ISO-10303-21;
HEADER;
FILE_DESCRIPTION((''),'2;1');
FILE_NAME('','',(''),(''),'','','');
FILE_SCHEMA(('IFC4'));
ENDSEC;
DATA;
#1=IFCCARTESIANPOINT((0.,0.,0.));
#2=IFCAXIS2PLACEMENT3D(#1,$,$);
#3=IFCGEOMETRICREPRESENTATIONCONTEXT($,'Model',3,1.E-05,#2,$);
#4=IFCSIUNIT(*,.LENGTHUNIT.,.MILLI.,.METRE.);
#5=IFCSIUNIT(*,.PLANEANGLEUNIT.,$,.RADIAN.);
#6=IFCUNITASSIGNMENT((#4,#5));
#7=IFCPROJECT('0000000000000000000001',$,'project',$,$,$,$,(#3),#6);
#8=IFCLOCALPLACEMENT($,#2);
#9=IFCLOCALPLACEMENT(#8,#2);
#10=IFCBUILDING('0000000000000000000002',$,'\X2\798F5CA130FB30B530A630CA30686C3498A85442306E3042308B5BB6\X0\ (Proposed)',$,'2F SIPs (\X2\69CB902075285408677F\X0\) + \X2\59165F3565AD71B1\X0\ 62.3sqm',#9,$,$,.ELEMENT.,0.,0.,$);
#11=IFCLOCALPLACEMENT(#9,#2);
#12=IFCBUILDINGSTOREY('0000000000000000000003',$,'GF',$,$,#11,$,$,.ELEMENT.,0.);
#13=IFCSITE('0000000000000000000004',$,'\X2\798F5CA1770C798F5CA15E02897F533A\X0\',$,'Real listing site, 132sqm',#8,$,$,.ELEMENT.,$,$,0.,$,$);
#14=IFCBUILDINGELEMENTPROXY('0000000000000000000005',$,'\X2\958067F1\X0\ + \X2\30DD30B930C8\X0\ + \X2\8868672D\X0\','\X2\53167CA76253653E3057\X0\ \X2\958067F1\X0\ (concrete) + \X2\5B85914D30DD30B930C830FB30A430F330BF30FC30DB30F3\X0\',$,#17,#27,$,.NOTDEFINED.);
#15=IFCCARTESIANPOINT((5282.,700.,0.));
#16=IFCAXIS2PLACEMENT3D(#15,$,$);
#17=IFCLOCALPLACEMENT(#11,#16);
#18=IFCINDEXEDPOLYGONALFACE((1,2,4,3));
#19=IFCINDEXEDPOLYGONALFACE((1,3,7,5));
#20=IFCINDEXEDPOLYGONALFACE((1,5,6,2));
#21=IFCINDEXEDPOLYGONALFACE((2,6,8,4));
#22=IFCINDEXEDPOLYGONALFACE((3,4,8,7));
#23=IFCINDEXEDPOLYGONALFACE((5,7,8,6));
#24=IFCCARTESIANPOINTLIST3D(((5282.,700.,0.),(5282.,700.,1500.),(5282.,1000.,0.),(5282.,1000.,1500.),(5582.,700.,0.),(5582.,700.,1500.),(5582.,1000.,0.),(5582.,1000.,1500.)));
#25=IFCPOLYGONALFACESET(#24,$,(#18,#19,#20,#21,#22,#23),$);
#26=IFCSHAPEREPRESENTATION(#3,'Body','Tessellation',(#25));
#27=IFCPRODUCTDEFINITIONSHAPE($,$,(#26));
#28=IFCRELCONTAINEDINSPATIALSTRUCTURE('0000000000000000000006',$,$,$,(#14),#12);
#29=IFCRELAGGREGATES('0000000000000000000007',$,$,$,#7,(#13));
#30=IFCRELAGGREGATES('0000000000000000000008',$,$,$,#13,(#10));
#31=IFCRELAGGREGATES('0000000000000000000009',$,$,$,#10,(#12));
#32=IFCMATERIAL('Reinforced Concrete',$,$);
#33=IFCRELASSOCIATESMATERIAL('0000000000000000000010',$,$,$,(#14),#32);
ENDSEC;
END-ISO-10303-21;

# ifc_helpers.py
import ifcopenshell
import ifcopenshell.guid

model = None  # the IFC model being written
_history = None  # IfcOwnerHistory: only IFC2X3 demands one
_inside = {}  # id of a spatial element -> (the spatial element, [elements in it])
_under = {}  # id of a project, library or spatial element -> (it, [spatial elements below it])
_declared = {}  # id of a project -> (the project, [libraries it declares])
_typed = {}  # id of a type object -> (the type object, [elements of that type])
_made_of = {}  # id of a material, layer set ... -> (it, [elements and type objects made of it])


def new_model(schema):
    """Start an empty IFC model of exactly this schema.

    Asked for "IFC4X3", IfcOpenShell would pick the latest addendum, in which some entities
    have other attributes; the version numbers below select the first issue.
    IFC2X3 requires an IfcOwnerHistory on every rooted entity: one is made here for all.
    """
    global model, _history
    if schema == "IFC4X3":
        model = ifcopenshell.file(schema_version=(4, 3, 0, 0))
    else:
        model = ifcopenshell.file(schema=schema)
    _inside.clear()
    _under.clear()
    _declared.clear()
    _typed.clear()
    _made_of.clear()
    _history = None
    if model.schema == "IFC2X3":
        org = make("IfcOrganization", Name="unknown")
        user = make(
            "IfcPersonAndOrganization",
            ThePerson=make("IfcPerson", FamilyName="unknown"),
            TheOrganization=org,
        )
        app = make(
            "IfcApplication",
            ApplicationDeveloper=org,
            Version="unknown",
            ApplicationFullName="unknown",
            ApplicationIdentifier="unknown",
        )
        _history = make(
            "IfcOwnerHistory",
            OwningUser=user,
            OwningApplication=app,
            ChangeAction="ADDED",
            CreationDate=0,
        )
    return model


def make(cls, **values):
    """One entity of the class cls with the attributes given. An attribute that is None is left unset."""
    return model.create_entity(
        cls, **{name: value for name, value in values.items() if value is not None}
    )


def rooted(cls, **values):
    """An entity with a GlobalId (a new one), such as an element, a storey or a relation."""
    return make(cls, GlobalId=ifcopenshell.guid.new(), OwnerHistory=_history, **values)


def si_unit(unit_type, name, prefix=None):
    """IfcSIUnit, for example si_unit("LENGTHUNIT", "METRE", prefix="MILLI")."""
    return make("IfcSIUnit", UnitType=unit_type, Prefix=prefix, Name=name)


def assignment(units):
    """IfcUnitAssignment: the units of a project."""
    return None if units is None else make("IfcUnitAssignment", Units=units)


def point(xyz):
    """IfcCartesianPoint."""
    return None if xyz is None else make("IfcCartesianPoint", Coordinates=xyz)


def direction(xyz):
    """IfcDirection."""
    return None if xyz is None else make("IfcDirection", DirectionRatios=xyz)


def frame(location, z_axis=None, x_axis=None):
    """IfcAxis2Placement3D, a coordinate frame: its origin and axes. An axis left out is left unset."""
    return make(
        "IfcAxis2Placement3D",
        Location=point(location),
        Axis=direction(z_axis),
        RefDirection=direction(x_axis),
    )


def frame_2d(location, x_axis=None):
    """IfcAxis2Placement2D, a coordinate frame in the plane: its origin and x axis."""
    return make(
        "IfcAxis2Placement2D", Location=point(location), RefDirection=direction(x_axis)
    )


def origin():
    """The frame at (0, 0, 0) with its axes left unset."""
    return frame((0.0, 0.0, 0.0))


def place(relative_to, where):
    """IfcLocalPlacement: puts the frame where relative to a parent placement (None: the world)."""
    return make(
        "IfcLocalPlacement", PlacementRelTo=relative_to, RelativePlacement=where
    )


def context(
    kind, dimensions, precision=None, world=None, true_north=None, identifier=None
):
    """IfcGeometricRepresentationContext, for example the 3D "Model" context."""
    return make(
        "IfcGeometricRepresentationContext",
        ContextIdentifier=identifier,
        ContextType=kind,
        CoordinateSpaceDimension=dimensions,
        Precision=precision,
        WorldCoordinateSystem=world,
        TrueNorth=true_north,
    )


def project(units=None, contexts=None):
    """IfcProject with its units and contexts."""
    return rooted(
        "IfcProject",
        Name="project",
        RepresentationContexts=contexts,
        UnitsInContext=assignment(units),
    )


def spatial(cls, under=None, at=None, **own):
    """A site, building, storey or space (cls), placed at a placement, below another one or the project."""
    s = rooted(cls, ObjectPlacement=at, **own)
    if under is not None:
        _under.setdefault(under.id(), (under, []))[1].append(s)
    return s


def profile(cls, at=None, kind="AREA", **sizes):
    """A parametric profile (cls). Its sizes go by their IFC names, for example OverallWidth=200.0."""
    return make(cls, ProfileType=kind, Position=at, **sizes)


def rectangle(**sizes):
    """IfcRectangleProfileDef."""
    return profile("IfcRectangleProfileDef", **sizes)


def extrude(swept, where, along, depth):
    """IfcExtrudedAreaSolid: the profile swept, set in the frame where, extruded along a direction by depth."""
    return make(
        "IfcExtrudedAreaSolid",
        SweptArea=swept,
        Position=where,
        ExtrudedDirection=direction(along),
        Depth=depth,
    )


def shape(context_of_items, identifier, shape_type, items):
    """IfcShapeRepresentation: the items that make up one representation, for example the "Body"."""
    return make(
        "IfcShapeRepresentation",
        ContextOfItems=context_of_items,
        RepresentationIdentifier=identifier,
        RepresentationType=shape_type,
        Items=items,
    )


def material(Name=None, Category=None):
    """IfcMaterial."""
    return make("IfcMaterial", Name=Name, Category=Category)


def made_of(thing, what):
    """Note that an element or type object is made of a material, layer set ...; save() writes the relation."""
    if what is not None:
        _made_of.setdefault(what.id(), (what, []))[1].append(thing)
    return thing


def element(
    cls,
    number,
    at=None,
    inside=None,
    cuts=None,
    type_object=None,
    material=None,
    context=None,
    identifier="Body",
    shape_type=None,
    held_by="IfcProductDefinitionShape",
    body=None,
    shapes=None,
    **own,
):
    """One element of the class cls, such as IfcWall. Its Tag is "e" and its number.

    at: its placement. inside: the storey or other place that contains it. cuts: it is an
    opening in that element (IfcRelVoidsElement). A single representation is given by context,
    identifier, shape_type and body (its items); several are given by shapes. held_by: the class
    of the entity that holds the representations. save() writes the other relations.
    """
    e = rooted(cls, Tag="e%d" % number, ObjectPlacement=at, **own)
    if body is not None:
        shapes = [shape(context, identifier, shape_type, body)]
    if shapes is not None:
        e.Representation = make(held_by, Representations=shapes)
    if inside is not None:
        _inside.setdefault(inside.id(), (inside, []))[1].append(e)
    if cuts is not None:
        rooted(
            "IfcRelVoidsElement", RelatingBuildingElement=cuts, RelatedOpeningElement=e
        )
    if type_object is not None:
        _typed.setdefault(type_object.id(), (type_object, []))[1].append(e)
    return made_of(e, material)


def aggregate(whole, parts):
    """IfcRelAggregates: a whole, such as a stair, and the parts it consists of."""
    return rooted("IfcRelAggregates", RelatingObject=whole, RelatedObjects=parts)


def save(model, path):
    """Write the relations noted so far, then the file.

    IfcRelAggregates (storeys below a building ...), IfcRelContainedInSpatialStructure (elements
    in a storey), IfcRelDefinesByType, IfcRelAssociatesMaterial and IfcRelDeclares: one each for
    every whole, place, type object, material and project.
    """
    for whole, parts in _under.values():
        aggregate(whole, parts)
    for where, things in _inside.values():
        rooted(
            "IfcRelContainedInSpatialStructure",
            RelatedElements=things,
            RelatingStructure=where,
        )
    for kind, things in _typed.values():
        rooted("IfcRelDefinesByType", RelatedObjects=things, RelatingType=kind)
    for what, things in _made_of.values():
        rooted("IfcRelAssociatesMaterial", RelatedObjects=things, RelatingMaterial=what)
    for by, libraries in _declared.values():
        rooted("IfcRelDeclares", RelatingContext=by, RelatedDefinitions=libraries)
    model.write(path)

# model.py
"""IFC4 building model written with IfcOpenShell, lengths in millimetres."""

from ifc_helpers import new_model, si_unit, frame, frame_2d, origin, place, context, project, spatial, rectangle, extrude, material, element, save


model = new_model("IFC4")

# Units and contexts
model_context = context("Model", 3, precision=1e-05, world=origin())
ifc_project = project(units=[si_unit("LENGTHUNIT", "METRE", prefix="MILLI"), si_unit("PLANEANGLEUNIT", "RADIAN")], contexts=[model_context])

# Site, building, storey
site_placement = place(None, origin())
site = spatial("IfcSite", under=ifc_project, at=site_placement, Name="福岡県福岡市西区", ObjectType="Real listing site, 132sqm", CompositionType="ELEMENT", RefElevation=0.0)
building_placement = place(site_placement, origin())
building = spatial("IfcBuilding", under=site, at=building_placement, Name="福岡・サウナと水風呂のある家 (Proposed)", ObjectType="2F SIPs (構造用合板) + 外張断熱 62.3sqm", CompositionType="ELEMENT", ElevationOfRefHeight=0.0, ElevationOfTerrain=0.0)
storey_placement = place(building_placement, origin())
storey = spatial("IfcBuildingStorey", under=building, at=storey_placement, Name="GF", CompositionType="ELEMENT", Elevation=0.0)

# Shared definitions
ifc_material_1 = material(Name="Reinforced Concrete")

# Building element proxy
proxy_placement = place(storey_placement, frame((5282.0, 700.0, 0.0)))
element("IfcBuildingElementProxy", 1, at=proxy_placement, inside=storey, material=ifc_material_1, Name="門柱 + ポスト + 表札", Description="化粧打放し 門柱 (concrete) + 宅配ポスト・インターホン", PredefinedType="NOTDEFINED", context=model_context, shape_type="SweptSolid", body=[
    extrude(rectangle(XDim=300.0, YDim=300.0, at=frame_2d((150.0, 150.0))), frame((5282.0, 700.0, 0.0)), (0.0, 0.0, 1.0), 1500.0),
])

save(model, "model.ifc")
